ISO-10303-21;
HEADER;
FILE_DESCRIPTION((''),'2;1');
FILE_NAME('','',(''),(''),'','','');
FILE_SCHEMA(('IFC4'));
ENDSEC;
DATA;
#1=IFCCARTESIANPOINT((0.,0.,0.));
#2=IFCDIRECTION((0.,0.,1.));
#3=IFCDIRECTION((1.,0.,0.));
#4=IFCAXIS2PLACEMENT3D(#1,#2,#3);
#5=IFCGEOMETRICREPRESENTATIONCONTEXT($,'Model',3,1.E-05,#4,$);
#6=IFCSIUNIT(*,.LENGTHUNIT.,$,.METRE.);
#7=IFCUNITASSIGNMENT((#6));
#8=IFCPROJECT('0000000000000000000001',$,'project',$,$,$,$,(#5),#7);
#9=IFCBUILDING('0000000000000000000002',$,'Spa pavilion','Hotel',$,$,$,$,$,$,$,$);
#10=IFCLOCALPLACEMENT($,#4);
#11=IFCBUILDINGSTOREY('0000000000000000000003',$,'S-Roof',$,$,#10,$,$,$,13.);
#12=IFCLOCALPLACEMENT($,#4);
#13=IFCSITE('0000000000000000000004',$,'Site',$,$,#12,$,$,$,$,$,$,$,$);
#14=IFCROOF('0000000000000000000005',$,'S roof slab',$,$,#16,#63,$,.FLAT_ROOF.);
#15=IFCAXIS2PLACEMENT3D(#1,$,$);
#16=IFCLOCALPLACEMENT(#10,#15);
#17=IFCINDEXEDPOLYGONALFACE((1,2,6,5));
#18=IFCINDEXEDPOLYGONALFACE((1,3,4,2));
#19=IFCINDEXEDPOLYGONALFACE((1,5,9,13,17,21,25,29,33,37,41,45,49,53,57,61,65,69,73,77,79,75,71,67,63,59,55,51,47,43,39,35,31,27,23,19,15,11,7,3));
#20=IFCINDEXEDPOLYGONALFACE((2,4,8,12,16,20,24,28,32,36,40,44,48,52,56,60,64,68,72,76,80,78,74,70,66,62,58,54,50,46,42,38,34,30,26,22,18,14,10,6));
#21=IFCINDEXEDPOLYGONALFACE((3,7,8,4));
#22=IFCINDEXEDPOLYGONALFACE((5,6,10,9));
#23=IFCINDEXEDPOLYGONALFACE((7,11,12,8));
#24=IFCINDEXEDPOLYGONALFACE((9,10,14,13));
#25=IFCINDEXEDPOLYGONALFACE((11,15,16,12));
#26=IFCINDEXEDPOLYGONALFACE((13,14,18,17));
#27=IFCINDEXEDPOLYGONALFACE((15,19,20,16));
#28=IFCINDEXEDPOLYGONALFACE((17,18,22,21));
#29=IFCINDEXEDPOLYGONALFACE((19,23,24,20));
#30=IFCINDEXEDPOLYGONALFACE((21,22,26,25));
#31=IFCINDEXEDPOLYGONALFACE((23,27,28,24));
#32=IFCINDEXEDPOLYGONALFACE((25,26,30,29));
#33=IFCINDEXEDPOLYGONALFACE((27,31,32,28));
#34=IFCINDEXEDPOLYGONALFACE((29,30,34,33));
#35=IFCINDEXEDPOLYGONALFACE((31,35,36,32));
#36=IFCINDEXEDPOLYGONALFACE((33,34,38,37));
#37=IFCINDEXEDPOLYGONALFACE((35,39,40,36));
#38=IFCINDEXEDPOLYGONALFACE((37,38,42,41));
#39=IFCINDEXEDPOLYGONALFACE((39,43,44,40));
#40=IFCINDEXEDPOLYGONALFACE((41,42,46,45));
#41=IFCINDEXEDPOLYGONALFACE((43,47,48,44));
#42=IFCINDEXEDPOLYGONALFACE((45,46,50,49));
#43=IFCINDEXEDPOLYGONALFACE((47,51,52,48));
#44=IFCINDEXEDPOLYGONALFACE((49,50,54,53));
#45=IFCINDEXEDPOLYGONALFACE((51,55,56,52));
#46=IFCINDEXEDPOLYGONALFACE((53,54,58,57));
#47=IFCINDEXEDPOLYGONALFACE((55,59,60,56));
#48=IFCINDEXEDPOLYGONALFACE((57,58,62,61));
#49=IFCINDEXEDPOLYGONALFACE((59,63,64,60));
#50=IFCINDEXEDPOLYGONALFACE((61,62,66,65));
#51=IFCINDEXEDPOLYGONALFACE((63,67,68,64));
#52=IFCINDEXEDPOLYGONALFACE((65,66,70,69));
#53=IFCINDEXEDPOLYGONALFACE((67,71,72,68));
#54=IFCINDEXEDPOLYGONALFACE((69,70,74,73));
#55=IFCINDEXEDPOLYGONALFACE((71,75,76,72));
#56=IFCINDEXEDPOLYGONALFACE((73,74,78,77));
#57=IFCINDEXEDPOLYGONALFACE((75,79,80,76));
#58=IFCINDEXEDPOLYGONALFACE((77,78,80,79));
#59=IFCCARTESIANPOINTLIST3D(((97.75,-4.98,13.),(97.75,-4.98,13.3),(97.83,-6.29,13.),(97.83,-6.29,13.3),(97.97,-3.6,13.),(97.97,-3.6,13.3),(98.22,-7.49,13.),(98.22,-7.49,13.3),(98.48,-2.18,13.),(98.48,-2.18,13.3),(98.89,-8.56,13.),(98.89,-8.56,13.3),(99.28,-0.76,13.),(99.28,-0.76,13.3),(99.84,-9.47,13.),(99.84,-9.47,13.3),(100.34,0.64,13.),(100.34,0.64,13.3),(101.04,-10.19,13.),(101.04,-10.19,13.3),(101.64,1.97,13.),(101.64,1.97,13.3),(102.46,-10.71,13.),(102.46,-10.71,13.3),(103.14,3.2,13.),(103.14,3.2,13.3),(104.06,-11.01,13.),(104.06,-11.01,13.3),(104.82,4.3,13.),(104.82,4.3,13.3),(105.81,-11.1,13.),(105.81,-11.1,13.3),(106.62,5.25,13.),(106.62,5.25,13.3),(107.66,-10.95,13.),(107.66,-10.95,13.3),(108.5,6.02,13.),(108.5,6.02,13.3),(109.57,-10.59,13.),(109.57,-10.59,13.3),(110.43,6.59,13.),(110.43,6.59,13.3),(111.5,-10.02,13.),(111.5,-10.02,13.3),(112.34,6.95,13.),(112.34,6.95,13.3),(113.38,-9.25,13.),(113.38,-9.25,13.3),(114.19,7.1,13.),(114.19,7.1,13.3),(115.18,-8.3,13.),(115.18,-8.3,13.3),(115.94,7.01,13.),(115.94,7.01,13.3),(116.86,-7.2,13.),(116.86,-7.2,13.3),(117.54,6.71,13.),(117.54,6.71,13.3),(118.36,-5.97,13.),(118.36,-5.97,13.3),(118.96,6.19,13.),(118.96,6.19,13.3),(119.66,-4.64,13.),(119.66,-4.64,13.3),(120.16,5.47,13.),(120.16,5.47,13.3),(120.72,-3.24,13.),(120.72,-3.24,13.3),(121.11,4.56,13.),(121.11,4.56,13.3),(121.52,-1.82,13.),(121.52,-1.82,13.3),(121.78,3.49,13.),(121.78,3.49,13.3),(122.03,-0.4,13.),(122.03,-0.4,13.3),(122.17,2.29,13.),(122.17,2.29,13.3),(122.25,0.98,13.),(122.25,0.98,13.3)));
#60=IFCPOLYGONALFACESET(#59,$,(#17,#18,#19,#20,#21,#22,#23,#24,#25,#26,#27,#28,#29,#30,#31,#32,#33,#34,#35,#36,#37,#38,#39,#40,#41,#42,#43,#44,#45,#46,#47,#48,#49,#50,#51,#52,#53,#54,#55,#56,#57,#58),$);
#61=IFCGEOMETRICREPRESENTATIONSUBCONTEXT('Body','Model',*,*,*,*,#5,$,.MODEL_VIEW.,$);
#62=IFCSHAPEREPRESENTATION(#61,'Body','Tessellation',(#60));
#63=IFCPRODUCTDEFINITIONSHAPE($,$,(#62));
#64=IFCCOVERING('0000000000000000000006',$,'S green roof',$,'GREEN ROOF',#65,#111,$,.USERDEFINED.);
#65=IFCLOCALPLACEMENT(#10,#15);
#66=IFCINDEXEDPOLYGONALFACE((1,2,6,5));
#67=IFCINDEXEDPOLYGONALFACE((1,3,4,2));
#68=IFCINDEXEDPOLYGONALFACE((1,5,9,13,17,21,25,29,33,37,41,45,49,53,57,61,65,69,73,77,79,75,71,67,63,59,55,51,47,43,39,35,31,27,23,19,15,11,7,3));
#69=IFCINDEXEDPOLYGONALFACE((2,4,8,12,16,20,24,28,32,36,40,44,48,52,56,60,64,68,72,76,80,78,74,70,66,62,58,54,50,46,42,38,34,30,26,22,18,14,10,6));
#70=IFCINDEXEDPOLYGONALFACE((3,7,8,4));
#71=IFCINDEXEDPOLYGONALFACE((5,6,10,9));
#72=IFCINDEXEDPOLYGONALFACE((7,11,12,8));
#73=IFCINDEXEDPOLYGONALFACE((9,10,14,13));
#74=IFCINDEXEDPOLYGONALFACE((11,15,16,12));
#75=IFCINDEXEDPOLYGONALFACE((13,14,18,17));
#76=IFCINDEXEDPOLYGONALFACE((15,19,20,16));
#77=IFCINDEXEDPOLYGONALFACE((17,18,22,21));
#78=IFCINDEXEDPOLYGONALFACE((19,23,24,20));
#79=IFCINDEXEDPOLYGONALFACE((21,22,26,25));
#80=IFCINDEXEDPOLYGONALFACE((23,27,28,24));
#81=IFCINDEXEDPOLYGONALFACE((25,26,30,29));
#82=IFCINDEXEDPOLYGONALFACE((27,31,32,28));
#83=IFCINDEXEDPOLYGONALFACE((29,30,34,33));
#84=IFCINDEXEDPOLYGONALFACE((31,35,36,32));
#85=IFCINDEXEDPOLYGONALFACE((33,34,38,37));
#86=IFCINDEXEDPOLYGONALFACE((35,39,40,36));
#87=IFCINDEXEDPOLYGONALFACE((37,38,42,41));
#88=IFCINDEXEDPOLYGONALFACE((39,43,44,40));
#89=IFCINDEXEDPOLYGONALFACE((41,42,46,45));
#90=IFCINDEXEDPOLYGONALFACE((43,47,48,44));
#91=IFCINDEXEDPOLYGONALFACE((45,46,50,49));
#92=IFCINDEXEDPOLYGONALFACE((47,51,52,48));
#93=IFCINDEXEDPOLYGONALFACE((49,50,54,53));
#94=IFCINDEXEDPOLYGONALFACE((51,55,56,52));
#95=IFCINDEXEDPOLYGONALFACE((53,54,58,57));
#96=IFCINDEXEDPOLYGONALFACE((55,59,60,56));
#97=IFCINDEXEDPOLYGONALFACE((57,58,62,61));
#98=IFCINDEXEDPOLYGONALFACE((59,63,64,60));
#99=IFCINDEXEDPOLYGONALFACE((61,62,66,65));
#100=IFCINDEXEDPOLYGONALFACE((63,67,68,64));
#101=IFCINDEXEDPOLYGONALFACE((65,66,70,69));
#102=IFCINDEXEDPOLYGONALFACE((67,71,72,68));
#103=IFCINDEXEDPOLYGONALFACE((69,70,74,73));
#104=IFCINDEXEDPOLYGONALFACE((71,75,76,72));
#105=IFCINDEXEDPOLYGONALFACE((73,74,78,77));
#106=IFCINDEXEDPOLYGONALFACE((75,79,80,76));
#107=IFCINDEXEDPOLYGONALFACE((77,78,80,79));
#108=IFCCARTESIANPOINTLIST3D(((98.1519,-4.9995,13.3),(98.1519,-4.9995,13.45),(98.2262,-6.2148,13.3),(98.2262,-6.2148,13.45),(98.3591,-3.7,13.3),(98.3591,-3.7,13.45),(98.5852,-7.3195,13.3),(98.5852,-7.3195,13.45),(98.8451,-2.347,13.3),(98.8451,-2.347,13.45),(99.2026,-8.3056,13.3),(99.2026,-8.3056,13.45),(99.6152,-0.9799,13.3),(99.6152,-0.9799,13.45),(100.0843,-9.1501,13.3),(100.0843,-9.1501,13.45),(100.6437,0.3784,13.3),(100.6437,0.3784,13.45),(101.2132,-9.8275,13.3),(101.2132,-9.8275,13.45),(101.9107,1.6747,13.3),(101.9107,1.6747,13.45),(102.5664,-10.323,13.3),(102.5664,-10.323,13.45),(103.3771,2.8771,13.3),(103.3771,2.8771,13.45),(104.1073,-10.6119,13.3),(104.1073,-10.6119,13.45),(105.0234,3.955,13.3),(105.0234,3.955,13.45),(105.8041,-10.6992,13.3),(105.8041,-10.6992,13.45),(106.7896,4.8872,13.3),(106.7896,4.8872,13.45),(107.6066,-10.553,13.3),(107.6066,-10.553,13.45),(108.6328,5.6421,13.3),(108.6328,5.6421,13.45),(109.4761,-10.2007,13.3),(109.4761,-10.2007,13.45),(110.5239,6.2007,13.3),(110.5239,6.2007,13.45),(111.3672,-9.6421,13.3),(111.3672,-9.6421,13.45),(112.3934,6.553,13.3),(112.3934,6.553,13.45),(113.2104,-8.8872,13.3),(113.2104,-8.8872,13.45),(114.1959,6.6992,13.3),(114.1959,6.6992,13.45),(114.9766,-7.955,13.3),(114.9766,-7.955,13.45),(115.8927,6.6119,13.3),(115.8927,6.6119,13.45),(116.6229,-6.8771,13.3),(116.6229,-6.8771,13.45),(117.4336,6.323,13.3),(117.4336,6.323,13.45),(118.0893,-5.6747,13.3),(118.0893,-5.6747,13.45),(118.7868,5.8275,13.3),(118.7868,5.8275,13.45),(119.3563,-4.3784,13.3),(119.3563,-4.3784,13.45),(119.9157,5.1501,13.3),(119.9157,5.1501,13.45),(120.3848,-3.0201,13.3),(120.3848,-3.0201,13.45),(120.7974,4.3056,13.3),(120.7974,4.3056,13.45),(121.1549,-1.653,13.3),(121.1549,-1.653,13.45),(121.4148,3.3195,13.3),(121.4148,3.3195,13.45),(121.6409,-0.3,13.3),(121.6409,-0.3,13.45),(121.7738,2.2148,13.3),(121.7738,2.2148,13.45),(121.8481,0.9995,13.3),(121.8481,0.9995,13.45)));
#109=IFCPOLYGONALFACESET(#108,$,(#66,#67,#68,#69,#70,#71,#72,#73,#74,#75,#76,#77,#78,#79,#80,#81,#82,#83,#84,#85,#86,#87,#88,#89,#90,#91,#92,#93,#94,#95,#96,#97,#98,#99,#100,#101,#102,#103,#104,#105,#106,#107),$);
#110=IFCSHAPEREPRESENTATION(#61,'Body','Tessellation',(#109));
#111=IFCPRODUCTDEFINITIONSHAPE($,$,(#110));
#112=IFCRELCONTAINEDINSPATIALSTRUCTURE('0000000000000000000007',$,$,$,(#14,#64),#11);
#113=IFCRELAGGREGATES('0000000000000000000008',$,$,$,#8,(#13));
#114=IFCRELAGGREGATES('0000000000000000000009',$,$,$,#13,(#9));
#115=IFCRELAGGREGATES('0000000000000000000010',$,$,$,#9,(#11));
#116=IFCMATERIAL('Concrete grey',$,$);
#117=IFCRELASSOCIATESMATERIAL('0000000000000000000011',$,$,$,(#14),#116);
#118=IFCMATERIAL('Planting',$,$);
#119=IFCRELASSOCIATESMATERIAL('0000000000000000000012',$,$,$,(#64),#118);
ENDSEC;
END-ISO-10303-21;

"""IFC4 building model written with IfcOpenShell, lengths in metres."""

from ifc_helpers import new_model, si_unit, frame, origin_with_axes, place, context, subcontext, project, spatial, polyline, outline, extrude, material, element, save


model = new_model("IFC4")

# Units and contexts
model_context = context("Model", 3, precision=1e-05, world=origin_with_axes())
body_context = subcontext(model_context, "Body", "Model", "MODEL_VIEW")
ifc_project = project(units=[si_unit("LENGTHUNIT", "METRE")], contexts=[model_context])

# Site, building, storey
site_placement = place(None, origin_with_axes())
site = spatial("IfcSite", under=ifc_project, at=site_placement, Name="Site")
building = spatial("IfcBuilding", under=site, Name="Spa pavilion", Description="Hotel")
storey_placement = place(None, origin_with_axes())
storey = spatial("IfcBuildingStorey", under=building, at=storey_placement, Name="S-Roof", Elevation=13.0)

# Roof
ifc_material_1 = material(Name="Concrete grey")
roof_placement = place(storey_placement, origin_with_axes())
element("IfcRoof", 1, at=roof_placement, inside=storey, material=ifc_material_1, Name="S roof slab", PredefinedType="FLAT_ROOF", context=body_context, shape_type="SweptSolid", body=[
    extrude(outline(polyline([(121.78, 3.49), (121.11, 4.56), (120.16, 5.47), (118.96, 6.19), (117.54, 6.71), (115.94, 7.01), (114.19, 7.1), (112.34, 6.95), (110.43, 6.59), (108.5, 6.02), (106.62, 5.25), (104.82, 4.3), (103.14, 3.2), (101.64, 1.97), (100.34, 0.64), (99.28, -0.76), (98.48, -2.18), (97.97, -3.6), (97.75, -4.98), (97.83, -6.29), (98.22, -7.49), (98.89, -8.56), (99.84, -9.47), (101.04, -10.19), (102.46, -10.71), (104.06, -11.01), (105.81, -11.1), (107.66, -10.95), (109.57, -10.59), (111.5, -10.02), (113.38, -9.25), (115.18, -8.3), (116.86, -7.2), (118.36, -5.97), (119.66, -4.64), (120.72, -3.24), (121.52, -1.82), (122.03, -0.4), (122.25, 0.98), (122.17, 2.29), (121.78, 3.49)])), frame((0.0, 0.0, 13.0), z_axis=(0.0, 0.0, 1.0), x_axis=(1.0, 0.0, 0.0)), (0.0, 0.0, 1.0), 0.3),
])

# Covering
ifc_material_2 = material(Name="Planting")
covering_placement = place(storey_placement, origin_with_axes())
element("IfcCovering", 2, at=covering_placement, inside=storey, material=ifc_material_2, Name="S green roof", ObjectType="GREEN ROOF", PredefinedType="USERDEFINED", context=body_context, shape_type="SweptSolid", body=[
    extrude(outline(polyline([(121.4148, 3.3195), (120.7974, 4.3056), (119.9157, 5.1501), (118.7868, 5.8275), (117.4336, 6.323), (115.8927, 6.6119), (114.1959, 6.6992), (112.3934, 6.553), (110.5239, 6.2007), (108.6328, 5.6421), (106.7896, 4.8872), (105.0234, 3.955), (103.3771, 2.8771), (101.9107, 1.6747), (100.6437, 0.3784), (99.6152, -0.9799), (98.8451, -2.347), (98.3591, -3.7), (98.1519, -4.9995), (98.2262, -6.2148), (98.5852, -7.3195), (99.2026, -8.3056), (100.0843, -9.1501), (101.2132, -9.8275), (102.5664, -10.323), (104.1073, -10.6119), (105.8041, -10.6992), (107.6066, -10.553), (109.4761, -10.2007), (111.3672, -9.6421), (113.2104, -8.8872), (114.9766, -7.955), (116.6229, -6.8771), (118.0893, -5.6747), (119.3563, -4.3784), (120.3848, -3.0201), (121.1549, -1.653), (121.6409, -0.3), (121.8481, 0.9995), (121.7738, 2.2148), (121.4148, 3.3195)])), frame((0.0, 0.0, 13.3), z_axis=(0.0, 0.0, 1.0), x_axis=(1.0, 0.0, 0.0)), (0.0, 0.0, 1.0), 0.15),
])

save(model, "model.ifc")
